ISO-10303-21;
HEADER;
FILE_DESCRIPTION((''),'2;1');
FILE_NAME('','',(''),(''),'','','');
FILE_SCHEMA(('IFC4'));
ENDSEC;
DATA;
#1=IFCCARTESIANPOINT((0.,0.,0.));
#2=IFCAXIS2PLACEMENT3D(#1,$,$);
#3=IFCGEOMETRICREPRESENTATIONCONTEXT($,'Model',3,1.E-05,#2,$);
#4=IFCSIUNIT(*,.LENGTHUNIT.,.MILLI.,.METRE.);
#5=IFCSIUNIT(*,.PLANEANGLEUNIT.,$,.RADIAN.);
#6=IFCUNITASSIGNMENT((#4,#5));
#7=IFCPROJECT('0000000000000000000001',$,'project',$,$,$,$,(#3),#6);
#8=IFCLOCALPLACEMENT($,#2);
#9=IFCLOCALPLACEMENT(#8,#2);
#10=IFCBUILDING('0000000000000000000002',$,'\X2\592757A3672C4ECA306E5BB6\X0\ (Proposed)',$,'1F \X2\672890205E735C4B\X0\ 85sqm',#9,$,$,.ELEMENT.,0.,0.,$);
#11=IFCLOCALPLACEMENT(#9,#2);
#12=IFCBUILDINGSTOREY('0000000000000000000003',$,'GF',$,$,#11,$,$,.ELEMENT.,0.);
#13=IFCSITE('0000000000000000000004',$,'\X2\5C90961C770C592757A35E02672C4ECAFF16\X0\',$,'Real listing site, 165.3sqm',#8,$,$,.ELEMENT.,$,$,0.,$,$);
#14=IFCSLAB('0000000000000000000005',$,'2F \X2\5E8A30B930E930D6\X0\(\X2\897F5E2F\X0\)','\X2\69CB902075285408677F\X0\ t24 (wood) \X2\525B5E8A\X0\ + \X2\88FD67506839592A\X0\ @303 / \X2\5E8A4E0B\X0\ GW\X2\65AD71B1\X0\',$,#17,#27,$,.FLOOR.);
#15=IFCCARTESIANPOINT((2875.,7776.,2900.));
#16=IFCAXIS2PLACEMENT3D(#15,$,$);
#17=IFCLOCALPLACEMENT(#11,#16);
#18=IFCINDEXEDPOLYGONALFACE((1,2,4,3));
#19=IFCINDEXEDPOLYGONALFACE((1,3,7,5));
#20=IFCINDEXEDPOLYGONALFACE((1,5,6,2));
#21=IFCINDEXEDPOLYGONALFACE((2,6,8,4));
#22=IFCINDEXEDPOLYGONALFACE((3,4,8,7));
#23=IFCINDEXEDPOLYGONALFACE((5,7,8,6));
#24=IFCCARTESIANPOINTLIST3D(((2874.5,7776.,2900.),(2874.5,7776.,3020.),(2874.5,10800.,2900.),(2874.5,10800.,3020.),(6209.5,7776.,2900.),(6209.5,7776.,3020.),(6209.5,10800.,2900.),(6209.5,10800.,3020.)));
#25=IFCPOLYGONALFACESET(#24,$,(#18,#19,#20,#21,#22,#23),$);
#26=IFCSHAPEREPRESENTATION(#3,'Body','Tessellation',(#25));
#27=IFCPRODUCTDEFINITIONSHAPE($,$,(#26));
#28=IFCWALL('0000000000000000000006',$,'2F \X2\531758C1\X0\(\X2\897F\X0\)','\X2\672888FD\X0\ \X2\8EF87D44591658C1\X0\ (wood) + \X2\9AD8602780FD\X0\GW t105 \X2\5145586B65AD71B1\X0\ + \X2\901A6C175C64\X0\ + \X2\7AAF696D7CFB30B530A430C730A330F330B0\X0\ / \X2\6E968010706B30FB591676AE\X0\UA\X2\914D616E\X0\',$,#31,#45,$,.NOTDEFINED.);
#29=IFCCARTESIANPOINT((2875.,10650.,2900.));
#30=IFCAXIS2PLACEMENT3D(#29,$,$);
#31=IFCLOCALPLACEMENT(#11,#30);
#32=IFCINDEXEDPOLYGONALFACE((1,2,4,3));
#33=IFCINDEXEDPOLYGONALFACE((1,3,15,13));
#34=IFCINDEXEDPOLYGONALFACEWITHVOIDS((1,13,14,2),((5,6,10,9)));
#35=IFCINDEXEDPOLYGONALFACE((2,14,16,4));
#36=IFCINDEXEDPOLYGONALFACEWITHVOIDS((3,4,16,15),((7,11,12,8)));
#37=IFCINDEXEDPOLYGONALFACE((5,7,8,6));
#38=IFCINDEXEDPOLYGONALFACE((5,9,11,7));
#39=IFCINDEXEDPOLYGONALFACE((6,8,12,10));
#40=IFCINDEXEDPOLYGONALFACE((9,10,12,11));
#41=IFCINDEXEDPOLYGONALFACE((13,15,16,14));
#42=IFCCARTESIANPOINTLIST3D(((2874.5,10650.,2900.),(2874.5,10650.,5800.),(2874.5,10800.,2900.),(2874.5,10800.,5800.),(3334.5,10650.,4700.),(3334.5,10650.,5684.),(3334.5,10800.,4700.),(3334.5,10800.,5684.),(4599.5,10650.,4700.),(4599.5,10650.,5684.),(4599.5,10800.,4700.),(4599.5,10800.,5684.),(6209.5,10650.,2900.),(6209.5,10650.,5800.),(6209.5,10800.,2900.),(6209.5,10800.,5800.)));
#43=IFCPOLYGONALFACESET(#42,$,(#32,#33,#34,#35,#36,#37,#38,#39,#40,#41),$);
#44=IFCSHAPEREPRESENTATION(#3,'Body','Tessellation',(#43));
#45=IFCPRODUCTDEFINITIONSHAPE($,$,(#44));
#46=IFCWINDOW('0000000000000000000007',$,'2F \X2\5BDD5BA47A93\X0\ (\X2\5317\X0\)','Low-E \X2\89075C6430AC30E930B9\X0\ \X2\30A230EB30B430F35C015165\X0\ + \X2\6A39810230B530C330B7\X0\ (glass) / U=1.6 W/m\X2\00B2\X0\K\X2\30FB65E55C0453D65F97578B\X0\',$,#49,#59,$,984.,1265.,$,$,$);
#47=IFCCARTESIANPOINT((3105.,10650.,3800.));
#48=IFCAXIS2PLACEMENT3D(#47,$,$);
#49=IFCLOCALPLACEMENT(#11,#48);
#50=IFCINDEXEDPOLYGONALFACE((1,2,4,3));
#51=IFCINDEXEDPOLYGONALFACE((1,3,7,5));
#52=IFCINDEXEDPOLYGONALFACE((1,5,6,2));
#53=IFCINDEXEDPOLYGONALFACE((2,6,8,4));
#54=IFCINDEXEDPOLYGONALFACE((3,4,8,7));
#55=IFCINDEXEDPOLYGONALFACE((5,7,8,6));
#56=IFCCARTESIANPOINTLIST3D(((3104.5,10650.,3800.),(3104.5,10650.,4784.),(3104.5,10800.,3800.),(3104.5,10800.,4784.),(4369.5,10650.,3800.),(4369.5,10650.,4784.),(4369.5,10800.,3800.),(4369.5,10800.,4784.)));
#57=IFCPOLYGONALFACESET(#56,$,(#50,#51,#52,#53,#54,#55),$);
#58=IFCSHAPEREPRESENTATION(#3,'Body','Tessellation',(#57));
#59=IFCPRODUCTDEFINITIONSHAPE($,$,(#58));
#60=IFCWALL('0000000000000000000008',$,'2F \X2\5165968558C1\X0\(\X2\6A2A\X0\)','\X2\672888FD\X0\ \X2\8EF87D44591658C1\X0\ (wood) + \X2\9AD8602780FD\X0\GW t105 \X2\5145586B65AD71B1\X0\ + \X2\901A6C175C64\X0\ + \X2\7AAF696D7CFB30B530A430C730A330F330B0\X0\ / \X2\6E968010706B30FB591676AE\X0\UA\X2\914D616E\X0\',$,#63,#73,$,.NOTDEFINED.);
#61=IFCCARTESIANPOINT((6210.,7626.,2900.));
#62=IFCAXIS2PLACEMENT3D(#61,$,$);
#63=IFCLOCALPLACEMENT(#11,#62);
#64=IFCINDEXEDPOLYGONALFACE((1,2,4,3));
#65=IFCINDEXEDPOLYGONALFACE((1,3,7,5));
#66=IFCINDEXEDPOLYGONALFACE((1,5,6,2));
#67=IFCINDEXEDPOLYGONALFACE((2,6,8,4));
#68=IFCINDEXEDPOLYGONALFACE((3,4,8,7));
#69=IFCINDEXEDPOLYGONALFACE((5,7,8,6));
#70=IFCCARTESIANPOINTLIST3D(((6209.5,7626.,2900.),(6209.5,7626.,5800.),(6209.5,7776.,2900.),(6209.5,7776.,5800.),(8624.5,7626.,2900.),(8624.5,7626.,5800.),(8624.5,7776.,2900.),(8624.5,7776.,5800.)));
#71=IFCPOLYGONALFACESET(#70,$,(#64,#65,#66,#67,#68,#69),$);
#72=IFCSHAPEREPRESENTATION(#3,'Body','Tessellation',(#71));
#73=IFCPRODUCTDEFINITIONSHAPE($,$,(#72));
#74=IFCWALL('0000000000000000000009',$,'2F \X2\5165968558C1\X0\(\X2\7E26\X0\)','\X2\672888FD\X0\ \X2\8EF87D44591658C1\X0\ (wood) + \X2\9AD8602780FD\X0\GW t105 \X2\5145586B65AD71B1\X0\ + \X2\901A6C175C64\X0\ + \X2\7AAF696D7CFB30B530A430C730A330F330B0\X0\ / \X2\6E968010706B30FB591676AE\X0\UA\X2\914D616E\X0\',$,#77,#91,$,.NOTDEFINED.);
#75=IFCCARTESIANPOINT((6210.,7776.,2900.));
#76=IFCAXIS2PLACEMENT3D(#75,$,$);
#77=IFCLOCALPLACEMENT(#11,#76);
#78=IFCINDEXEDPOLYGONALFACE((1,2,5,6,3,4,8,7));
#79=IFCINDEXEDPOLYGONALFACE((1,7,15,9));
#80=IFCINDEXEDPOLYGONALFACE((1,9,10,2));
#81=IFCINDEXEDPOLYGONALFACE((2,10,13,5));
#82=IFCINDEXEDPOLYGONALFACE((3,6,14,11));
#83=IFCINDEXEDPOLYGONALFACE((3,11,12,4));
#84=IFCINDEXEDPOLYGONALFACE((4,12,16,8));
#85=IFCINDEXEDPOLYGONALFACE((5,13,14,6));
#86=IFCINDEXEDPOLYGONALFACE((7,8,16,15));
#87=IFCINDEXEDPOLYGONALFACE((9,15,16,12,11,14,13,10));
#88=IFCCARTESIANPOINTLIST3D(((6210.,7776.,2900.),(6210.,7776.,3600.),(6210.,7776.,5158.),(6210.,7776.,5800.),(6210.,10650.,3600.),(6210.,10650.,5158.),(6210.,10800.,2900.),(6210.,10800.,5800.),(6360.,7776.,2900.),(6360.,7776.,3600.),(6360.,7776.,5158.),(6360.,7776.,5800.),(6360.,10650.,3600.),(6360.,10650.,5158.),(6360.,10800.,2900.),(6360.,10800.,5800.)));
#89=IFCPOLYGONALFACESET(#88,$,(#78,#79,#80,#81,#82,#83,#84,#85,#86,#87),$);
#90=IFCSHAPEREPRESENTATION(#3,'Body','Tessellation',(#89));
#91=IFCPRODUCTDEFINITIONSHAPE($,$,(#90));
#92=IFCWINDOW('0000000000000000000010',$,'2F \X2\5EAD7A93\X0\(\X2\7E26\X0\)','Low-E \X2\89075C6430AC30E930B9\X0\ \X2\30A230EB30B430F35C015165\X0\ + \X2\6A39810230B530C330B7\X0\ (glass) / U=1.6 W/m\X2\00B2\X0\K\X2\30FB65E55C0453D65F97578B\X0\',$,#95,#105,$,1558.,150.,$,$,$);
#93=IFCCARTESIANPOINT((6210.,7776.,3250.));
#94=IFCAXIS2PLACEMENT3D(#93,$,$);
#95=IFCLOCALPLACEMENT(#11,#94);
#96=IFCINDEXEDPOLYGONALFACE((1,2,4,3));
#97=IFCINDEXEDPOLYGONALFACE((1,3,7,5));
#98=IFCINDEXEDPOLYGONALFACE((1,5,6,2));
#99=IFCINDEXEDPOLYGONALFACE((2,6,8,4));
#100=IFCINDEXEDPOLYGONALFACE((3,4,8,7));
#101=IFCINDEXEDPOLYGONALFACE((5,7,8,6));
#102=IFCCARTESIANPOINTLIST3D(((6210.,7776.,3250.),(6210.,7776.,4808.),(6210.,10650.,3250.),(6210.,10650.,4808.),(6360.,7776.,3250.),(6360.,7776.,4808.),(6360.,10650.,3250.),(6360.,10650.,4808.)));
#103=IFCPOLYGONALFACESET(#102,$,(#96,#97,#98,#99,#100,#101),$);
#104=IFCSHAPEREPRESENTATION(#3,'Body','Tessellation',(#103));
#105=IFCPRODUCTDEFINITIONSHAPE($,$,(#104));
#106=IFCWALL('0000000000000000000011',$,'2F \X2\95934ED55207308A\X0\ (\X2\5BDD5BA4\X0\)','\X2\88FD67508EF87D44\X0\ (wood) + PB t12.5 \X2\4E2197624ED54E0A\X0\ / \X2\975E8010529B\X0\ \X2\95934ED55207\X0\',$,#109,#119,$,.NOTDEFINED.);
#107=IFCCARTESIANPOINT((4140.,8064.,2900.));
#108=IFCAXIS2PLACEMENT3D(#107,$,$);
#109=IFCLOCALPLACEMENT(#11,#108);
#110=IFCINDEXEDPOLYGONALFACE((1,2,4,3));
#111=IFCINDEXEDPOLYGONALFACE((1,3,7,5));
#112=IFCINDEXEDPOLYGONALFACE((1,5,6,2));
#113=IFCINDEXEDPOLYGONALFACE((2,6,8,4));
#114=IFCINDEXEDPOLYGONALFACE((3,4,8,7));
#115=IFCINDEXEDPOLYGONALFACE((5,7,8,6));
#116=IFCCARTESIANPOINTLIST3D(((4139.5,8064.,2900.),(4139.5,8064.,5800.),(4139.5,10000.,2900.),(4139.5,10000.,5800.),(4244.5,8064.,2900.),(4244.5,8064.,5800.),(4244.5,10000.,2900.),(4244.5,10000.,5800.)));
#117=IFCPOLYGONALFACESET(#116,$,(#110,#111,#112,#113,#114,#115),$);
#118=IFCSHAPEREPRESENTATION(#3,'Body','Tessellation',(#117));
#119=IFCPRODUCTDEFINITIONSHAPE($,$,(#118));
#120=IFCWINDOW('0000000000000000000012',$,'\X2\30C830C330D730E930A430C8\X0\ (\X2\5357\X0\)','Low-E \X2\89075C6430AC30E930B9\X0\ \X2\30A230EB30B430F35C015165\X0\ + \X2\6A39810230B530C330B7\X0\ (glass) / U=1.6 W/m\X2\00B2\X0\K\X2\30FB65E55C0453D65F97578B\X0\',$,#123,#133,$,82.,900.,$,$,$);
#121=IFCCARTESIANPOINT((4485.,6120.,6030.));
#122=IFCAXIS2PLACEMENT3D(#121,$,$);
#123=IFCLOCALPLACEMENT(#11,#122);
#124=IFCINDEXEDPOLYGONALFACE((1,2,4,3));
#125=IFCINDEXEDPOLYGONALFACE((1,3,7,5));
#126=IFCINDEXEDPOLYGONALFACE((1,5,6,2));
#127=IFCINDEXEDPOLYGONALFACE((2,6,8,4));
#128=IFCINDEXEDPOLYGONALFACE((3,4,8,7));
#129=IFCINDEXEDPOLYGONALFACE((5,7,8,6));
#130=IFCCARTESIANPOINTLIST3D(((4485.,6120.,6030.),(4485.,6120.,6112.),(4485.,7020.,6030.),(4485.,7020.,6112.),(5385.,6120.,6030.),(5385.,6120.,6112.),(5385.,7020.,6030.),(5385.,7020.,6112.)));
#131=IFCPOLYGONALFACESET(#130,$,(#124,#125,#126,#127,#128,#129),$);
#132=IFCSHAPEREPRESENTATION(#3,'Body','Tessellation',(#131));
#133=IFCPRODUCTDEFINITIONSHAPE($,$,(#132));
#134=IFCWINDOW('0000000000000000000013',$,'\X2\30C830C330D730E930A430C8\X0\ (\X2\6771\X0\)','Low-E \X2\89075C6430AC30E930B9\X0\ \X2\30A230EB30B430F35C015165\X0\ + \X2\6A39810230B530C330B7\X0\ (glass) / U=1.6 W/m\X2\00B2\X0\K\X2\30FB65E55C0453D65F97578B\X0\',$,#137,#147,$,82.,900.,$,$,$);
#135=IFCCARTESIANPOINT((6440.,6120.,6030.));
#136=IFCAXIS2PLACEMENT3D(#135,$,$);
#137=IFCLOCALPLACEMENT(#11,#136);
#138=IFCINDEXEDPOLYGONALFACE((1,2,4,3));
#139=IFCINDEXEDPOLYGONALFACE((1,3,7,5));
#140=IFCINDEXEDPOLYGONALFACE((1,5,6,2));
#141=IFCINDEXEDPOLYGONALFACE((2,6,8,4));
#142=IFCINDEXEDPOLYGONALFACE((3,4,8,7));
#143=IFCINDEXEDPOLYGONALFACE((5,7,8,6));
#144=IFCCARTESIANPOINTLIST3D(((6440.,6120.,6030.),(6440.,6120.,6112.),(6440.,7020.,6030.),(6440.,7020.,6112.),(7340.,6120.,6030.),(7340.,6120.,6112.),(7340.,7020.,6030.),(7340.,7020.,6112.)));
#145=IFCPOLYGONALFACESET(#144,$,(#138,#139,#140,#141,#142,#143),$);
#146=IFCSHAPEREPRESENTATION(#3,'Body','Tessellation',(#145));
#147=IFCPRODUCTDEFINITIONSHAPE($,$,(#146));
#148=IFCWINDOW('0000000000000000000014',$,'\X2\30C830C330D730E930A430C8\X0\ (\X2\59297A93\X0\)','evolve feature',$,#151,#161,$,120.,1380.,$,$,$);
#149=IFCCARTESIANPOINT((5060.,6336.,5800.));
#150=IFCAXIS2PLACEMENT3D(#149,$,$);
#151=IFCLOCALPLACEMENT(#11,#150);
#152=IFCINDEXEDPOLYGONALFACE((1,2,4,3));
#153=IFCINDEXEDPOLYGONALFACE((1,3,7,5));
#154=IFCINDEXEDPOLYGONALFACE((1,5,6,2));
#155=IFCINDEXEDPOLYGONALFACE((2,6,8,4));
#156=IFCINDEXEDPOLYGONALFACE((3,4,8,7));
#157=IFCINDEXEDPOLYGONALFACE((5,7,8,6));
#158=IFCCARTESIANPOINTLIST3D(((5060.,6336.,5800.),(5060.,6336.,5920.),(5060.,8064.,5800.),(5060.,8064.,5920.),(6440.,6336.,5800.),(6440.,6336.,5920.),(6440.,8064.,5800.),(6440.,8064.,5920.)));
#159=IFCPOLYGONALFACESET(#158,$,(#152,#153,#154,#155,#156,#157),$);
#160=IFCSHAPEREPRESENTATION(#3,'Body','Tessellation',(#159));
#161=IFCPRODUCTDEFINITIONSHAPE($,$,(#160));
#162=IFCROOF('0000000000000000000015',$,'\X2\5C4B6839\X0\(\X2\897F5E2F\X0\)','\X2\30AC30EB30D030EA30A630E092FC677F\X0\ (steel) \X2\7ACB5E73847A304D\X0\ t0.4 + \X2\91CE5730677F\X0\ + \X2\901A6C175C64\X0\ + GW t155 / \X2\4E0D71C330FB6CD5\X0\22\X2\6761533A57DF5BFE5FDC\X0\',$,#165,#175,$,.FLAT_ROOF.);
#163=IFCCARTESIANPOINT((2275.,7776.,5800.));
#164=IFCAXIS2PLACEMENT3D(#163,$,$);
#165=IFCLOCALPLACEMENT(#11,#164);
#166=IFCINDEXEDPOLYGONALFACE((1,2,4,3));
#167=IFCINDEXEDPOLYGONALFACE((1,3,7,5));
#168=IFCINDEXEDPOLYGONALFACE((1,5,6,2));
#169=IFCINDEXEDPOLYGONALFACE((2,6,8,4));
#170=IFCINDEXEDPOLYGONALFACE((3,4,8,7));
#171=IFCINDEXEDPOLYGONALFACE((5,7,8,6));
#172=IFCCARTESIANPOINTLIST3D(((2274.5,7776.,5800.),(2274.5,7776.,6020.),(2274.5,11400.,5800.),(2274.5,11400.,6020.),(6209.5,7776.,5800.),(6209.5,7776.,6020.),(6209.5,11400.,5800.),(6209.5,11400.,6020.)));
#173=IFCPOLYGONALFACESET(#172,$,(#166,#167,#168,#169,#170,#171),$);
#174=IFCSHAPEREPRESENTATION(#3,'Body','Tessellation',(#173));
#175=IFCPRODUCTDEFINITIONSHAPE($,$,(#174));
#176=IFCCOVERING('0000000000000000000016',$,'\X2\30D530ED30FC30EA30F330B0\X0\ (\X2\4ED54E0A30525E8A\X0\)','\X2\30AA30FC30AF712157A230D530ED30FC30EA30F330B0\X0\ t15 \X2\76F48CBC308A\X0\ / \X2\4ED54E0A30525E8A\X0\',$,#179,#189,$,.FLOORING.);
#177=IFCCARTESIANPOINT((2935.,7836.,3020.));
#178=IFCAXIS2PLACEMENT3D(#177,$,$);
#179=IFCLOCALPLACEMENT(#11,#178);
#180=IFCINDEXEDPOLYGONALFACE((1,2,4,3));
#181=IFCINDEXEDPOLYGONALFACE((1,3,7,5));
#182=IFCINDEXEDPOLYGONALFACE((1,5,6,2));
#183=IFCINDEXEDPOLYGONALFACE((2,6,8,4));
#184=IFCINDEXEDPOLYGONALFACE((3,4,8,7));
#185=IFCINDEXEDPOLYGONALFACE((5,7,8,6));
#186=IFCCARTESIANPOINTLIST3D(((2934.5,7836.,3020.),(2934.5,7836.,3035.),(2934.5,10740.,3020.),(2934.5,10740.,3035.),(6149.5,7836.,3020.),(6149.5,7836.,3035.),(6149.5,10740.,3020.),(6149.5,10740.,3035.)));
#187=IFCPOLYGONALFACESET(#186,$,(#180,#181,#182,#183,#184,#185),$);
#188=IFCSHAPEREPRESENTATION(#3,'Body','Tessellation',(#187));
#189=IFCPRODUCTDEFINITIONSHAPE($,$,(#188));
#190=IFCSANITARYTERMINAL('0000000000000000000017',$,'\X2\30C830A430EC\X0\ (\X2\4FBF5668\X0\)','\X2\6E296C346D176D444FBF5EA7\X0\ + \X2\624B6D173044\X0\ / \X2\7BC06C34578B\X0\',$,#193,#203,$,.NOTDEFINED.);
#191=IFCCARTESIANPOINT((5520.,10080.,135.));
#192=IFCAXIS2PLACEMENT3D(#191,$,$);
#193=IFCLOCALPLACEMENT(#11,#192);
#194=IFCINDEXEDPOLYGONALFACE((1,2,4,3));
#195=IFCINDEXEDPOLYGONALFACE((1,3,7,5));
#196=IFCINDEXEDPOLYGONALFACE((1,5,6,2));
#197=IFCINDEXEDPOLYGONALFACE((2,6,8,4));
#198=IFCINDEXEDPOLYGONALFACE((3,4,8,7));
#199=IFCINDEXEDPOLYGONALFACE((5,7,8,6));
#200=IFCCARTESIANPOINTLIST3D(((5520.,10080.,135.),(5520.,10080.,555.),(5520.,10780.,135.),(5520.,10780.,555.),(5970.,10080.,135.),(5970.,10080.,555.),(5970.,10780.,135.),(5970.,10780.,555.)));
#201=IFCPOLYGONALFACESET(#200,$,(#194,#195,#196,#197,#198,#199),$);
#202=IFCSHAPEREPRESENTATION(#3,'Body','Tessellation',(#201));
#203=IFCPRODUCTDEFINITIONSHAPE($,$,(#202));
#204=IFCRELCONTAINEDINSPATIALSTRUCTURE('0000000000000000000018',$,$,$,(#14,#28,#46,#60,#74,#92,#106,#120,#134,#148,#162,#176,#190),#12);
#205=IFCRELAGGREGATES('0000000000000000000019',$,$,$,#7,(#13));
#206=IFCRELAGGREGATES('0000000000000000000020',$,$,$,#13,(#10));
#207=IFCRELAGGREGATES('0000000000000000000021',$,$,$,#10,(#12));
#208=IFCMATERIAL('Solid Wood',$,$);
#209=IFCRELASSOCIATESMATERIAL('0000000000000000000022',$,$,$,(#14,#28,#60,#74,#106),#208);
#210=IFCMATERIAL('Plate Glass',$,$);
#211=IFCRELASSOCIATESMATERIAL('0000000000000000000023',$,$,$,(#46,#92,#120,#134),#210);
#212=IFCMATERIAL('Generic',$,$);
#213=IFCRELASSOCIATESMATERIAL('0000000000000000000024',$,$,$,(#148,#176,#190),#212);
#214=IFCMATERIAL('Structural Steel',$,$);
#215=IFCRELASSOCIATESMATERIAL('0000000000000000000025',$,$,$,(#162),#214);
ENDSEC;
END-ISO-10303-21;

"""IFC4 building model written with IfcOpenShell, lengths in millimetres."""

from ifc_helpers import new_model, si_unit, frame, frame_2d, origin, place, context, project, spatial, rectangle, extrude, material, element, fill, save


model = new_model("IFC4")

# Units and contexts
model_context = context("Model", 3, precision=1e-05, world=origin())
ifc_project = project(units=[si_unit("LENGTHUNIT", "METRE", prefix="MILLI"), si_unit("PLANEANGLEUNIT", "RADIAN")], contexts=[model_context])

# Site, building, storey
site_placement = place(None, origin())
site = spatial("IfcSite", under=ifc_project, at=site_placement, Name="岐阜県大垣市本今６", ObjectType="Real listing site, 165.3sqm", CompositionType="ELEMENT", RefElevation=0.0)
building_placement = place(site_placement, origin())
building = spatial("IfcBuilding", under=site, at=building_placement, Name="大垣本今の家 (Proposed)", ObjectType="1F 木造平屋 85sqm", CompositionType="ELEMENT", ElevationOfRefHeight=0.0, ElevationOfTerrain=0.0)
storey_placement = place(building_placement, origin())
storey = spatial("IfcBuildingStorey", under=building, at=storey_placement, Name="GF", CompositionType="ELEMENT", Elevation=0.0)

# Slab
ifc_material_1 = material(Name="Solid Wood")
slab_placement = place(storey_placement, frame((2875.0, 7776.0, 2900.0)))
element("IfcSlab", 1, at=slab_placement, inside=storey, material=ifc_material_1, Name="2F 床スラブ(西帯)", Description="構造用合板 t24 (wood) 剛床 + 製材根太 @303 / 床下 GW断熱", PredefinedType="FLOOR", context=model_context, shape_type="SweptSolid", body=[
    extrude(rectangle(XDim=3335.0, YDim=3024.0, at=frame_2d((1667.0, 1512.0))), frame((2875.0, 7776.0, 2900.0)), (0.0, 0.0, 1.0), 120.0),
])

# Wall, opening, window
wall_1_placement = place(storey_placement, frame((2875.0, 10650.0, 2900.0)))
wall_1 = element("IfcWall", 2, at=wall_1_placement, inside=storey, material=ifc_material_1, Name="2F 北壁(西)", Description="木製 軸組外壁 (wood) + 高性能GW t105 充填断熱 + 通気層 + 窯業系サイディング / 準耐火・外皮UA配慮", PredefinedType="NOTDEFINED", context=model_context, shape_type="SweptSolid", body=[
    extrude(rectangle(XDim=3335.0, YDim=150.0, at=frame_2d((1667.0, 75.0))), frame((2875.0, 10650.0, 2900.0)), (0.0, 0.0, 1.0), 2900.0),
])
opening_1_placement = place(storey_placement, frame((3105.0, 10650.0, 3800.0)))
opening_1 = element("IfcOpeningElement", 3, at=opening_1_placement, cuts=wall_1, PredefinedType="NOTDEFINED", context=model_context, shape_type="SweptSolid", body=[
    extrude(rectangle(XDim=1265.0, YDim=150.0, at=frame_2d((632.0, 75.0))), frame((3105.0, 10650.0, 3800.0)), (0.0, 0.0, 1.0), 984.0),
])
ifc_material_2 = material(Name="Plate Glass")
window_1_placement = place(storey_placement, frame((3105.0, 10650.0, 3800.0)))
window_1 = element("IfcWindow", 4, at=window_1_placement, inside=storey, material=ifc_material_2, Name="2F 寝室窓 (北)", Description="Low-E 複層ガラス アルゴン封入 + 樹脂サッシ (glass) / U=1.6 W/m²K・日射取得型", OverallHeight=984.0, OverallWidth=1265.0, context=model_context, shape_type="SweptSolid", body=[
    extrude(rectangle(XDim=1265.0, YDim=150.0, at=frame_2d((632.0, 75.0))), frame((3105.0, 10650.0, 3800.0)), (0.0, 0.0, 1.0), 984.0),
])
fill(opening_1, window_1)

# Wall
wall_2_placement = place(storey_placement, frame((6210.0, 7626.0, 2900.0)))
element("IfcWall", 5, at=wall_2_placement, inside=storey, material=ifc_material_1, Name="2F 入隅壁(横)", Description="木製 軸組外壁 (wood) + 高性能GW t105 充填断熱 + 通気層 + 窯業系サイディング / 準耐火・外皮UA配慮", PredefinedType="NOTDEFINED", context=model_context, shape_type="SweptSolid", body=[
    extrude(rectangle(XDim=2415.0, YDim=150.0, at=frame_2d((1207.0, 75.0))), frame((6210.0, 7626.0, 2900.0)), (0.0, 0.0, 1.0), 2900.0),
])

# Wall, opening, window
wall_3_placement = place(storey_placement, frame((6210.0, 7776.0, 2900.0)))
wall_3 = element("IfcWall", 6, at=wall_3_placement, inside=storey, material=ifc_material_1, Name="2F 入隅壁(縦)", Description="木製 軸組外壁 (wood) + 高性能GW t105 充填断熱 + 通気層 + 窯業系サイディング / 準耐火・外皮UA配慮", PredefinedType="NOTDEFINED", context=model_context, shape_type="SweptSolid", body=[
    extrude(rectangle(XDim=150.0, YDim=3024.0, at=frame_2d((75.0, 1512.0))), frame((6210.0, 7776.0, 2900.0)), (0.0, 0.0, 1.0), 2900.0),
])
opening_2_placement = place(storey_placement, frame((6210.0, 7776.0, 3250.0)))
opening_2 = element("IfcOpeningElement", 7, at=opening_2_placement, cuts=wall_3, PredefinedType="NOTDEFINED", context=model_context, shape_type="SweptSolid", body=[
    extrude(rectangle(XDim=150.0, YDim=2874.0, at=frame_2d((75.0, 1437.0))), frame((6210.0, 7776.0, 3250.0)), (0.0, 0.0, 1.0), 1558.0),
])
window_2_placement = place(storey_placement, frame((6210.0, 7776.0, 3250.0)))
window_2 = element("IfcWindow", 8, at=window_2_placement, inside=storey, material=ifc_material_2, Name="2F 庭窓(縦)", Description="Low-E 複層ガラス アルゴン封入 + 樹脂サッシ (glass) / U=1.6 W/m²K・日射取得型", OverallHeight=1558.0, OverallWidth=150.0, context=model_context, shape_type="SweptSolid", body=[
    extrude(rectangle(XDim=150.0, YDim=2874.0, at=frame_2d((75.0, 1437.0))), frame((6210.0, 7776.0, 3250.0)), (0.0, 0.0, 1.0), 1558.0),
])
fill(opening_2, window_2)

# Wall
wall_4_placement = place(storey_placement, frame((4140.0, 8064.0, 2900.0)))
element("IfcWall", 9, at=wall_4_placement, inside=storey, material=ifc_material_1, Name="2F 間仕切り (寝室)", Description="製材軸組 (wood) + PB t12.5 両面仕上 / 非耐力 間仕切", PredefinedType="NOTDEFINED", context=model_context, shape_type="SweptSolid", body=[
    extrude(rectangle(XDim=105.0, YDim=1936.0, at=frame_2d((52.0, 968.0))), frame((4140.0, 8064.0, 2900.0)), (0.0, 0.0, 1.0), 2900.0),
])

# Windows
window_3_placement = place(storey_placement, frame((4485.0, 6120.0, 6030.0)))
element("IfcWindow", 10, at=window_3_placement, inside=storey, material=ifc_material_2, Name="トップライト (南)", Description="Low-E 複層ガラス アルゴン封入 + 樹脂サッシ (glass) / U=1.6 W/m²K・日射取得型", OverallHeight=82.0, OverallWidth=900.0, context=model_context, shape_type="SweptSolid", body=[
    extrude(rectangle(XDim=900.0, YDim=900.0, at=frame_2d((450.0, 450.0))), frame((4485.0, 6120.0, 6030.0)), (0.0, 0.0, 1.0), 82.0),
])
window_4_placement = place(storey_placement, frame((6440.0, 6120.0, 6030.0)))
element("IfcWindow", 11, at=window_4_placement, inside=storey, material=ifc_material_2, Name="トップライト (東)", Description="Low-E 複層ガラス アルゴン封入 + 樹脂サッシ (glass) / U=1.6 W/m²K・日射取得型", OverallHeight=82.0, OverallWidth=900.0, context=model_context, shape_type="SweptSolid", body=[
    extrude(rectangle(XDim=900.0, YDim=900.0, at=frame_2d((450.0, 450.0))), frame((6440.0, 6120.0, 6030.0)), (0.0, 0.0, 1.0), 82.0),
])
ifc_material_3 = material(Name="Generic")
window_5_placement = place(storey_placement, frame((5060.0, 6336.0, 5800.0)))
element("IfcWindow", 12, at=window_5_placement, inside=storey, material=ifc_material_3, Name="トップライト (天窓)", Description="evolve feature", OverallHeight=120.0, OverallWidth=1380.0, context=model_context, shape_type="SweptSolid", body=[
    extrude(rectangle(XDim=1380.0, YDim=1728.0, at=frame_2d((690.0, 864.0))), frame((5060.0, 6336.0, 5800.0)), (0.0, 0.0, 1.0), 120.0),
])

# Roof
ifc_material_4 = material(Name="Structural Steel")
for number, where, name in (
    (13, (2275.0, 7776.0, 5800.0), "屋根(西帯)"),
):
    element("IfcRoof", number, at=place(storey_placement, frame(where)), inside=storey, material=ifc_material_4, Name=name, Description="ガルバリウム鋼板 (steel) 立平葺き t0.4 + 野地板 + 通気層 + GW t155 / 不燃・法22条区域対応", PredefinedType="FLAT_ROOF", context=model_context, shape_type="SweptSolid", body=[
        extrude(rectangle(XDim=3935.0, YDim=3624.0, at=frame_2d((1967.0, 1812.0))), frame((2275.0, 7776.0, 5800.0)), (0.0, 0.0, 1.0), 220.0),
    ])

# Covering
covering_placement = place(storey_placement, frame((2935.0, 7836.0, 3020.0)))
element("IfcCovering", 14, at=covering_placement, inside=storey, material=ifc_material_3, Name="フローリング (仕上げ床)", Description="オーク無垢フローリング t15 直貼り / 仕上げ床", PredefinedType="FLOORING", context=model_context, shape_type="SweptSolid", body=[
    extrude(rectangle(XDim=3215.0, YDim=2904.0, at=frame_2d((1607.0, 1452.0))), frame((2935.0, 7836.0, 3020.0)), (0.0, 0.0, 1.0), 15.0),
])

# Sanitary terminal
sanitary_terminal_placement = place(storey_placement, frame((5520.0, 10080.0, 135.0)))
element("IfcSanitaryTerminal", 15, at=sanitary_terminal_placement, inside=storey, material=ifc_material_3, Name="トイレ (便器)", Description="温水洗浄便座 + 手洗い / 節水型", PredefinedType="NOTDEFINED", context=model_context, shape_type="SweptSolid", body=[
    extrude(rectangle(XDim=450.0, YDim=700.0, at=frame_2d((225.0, 350.0))), frame((5520.0, 10080.0, 135.0)), (0.0, 0.0, 1.0), 420.0),
])

save(model, "model.ifc")
